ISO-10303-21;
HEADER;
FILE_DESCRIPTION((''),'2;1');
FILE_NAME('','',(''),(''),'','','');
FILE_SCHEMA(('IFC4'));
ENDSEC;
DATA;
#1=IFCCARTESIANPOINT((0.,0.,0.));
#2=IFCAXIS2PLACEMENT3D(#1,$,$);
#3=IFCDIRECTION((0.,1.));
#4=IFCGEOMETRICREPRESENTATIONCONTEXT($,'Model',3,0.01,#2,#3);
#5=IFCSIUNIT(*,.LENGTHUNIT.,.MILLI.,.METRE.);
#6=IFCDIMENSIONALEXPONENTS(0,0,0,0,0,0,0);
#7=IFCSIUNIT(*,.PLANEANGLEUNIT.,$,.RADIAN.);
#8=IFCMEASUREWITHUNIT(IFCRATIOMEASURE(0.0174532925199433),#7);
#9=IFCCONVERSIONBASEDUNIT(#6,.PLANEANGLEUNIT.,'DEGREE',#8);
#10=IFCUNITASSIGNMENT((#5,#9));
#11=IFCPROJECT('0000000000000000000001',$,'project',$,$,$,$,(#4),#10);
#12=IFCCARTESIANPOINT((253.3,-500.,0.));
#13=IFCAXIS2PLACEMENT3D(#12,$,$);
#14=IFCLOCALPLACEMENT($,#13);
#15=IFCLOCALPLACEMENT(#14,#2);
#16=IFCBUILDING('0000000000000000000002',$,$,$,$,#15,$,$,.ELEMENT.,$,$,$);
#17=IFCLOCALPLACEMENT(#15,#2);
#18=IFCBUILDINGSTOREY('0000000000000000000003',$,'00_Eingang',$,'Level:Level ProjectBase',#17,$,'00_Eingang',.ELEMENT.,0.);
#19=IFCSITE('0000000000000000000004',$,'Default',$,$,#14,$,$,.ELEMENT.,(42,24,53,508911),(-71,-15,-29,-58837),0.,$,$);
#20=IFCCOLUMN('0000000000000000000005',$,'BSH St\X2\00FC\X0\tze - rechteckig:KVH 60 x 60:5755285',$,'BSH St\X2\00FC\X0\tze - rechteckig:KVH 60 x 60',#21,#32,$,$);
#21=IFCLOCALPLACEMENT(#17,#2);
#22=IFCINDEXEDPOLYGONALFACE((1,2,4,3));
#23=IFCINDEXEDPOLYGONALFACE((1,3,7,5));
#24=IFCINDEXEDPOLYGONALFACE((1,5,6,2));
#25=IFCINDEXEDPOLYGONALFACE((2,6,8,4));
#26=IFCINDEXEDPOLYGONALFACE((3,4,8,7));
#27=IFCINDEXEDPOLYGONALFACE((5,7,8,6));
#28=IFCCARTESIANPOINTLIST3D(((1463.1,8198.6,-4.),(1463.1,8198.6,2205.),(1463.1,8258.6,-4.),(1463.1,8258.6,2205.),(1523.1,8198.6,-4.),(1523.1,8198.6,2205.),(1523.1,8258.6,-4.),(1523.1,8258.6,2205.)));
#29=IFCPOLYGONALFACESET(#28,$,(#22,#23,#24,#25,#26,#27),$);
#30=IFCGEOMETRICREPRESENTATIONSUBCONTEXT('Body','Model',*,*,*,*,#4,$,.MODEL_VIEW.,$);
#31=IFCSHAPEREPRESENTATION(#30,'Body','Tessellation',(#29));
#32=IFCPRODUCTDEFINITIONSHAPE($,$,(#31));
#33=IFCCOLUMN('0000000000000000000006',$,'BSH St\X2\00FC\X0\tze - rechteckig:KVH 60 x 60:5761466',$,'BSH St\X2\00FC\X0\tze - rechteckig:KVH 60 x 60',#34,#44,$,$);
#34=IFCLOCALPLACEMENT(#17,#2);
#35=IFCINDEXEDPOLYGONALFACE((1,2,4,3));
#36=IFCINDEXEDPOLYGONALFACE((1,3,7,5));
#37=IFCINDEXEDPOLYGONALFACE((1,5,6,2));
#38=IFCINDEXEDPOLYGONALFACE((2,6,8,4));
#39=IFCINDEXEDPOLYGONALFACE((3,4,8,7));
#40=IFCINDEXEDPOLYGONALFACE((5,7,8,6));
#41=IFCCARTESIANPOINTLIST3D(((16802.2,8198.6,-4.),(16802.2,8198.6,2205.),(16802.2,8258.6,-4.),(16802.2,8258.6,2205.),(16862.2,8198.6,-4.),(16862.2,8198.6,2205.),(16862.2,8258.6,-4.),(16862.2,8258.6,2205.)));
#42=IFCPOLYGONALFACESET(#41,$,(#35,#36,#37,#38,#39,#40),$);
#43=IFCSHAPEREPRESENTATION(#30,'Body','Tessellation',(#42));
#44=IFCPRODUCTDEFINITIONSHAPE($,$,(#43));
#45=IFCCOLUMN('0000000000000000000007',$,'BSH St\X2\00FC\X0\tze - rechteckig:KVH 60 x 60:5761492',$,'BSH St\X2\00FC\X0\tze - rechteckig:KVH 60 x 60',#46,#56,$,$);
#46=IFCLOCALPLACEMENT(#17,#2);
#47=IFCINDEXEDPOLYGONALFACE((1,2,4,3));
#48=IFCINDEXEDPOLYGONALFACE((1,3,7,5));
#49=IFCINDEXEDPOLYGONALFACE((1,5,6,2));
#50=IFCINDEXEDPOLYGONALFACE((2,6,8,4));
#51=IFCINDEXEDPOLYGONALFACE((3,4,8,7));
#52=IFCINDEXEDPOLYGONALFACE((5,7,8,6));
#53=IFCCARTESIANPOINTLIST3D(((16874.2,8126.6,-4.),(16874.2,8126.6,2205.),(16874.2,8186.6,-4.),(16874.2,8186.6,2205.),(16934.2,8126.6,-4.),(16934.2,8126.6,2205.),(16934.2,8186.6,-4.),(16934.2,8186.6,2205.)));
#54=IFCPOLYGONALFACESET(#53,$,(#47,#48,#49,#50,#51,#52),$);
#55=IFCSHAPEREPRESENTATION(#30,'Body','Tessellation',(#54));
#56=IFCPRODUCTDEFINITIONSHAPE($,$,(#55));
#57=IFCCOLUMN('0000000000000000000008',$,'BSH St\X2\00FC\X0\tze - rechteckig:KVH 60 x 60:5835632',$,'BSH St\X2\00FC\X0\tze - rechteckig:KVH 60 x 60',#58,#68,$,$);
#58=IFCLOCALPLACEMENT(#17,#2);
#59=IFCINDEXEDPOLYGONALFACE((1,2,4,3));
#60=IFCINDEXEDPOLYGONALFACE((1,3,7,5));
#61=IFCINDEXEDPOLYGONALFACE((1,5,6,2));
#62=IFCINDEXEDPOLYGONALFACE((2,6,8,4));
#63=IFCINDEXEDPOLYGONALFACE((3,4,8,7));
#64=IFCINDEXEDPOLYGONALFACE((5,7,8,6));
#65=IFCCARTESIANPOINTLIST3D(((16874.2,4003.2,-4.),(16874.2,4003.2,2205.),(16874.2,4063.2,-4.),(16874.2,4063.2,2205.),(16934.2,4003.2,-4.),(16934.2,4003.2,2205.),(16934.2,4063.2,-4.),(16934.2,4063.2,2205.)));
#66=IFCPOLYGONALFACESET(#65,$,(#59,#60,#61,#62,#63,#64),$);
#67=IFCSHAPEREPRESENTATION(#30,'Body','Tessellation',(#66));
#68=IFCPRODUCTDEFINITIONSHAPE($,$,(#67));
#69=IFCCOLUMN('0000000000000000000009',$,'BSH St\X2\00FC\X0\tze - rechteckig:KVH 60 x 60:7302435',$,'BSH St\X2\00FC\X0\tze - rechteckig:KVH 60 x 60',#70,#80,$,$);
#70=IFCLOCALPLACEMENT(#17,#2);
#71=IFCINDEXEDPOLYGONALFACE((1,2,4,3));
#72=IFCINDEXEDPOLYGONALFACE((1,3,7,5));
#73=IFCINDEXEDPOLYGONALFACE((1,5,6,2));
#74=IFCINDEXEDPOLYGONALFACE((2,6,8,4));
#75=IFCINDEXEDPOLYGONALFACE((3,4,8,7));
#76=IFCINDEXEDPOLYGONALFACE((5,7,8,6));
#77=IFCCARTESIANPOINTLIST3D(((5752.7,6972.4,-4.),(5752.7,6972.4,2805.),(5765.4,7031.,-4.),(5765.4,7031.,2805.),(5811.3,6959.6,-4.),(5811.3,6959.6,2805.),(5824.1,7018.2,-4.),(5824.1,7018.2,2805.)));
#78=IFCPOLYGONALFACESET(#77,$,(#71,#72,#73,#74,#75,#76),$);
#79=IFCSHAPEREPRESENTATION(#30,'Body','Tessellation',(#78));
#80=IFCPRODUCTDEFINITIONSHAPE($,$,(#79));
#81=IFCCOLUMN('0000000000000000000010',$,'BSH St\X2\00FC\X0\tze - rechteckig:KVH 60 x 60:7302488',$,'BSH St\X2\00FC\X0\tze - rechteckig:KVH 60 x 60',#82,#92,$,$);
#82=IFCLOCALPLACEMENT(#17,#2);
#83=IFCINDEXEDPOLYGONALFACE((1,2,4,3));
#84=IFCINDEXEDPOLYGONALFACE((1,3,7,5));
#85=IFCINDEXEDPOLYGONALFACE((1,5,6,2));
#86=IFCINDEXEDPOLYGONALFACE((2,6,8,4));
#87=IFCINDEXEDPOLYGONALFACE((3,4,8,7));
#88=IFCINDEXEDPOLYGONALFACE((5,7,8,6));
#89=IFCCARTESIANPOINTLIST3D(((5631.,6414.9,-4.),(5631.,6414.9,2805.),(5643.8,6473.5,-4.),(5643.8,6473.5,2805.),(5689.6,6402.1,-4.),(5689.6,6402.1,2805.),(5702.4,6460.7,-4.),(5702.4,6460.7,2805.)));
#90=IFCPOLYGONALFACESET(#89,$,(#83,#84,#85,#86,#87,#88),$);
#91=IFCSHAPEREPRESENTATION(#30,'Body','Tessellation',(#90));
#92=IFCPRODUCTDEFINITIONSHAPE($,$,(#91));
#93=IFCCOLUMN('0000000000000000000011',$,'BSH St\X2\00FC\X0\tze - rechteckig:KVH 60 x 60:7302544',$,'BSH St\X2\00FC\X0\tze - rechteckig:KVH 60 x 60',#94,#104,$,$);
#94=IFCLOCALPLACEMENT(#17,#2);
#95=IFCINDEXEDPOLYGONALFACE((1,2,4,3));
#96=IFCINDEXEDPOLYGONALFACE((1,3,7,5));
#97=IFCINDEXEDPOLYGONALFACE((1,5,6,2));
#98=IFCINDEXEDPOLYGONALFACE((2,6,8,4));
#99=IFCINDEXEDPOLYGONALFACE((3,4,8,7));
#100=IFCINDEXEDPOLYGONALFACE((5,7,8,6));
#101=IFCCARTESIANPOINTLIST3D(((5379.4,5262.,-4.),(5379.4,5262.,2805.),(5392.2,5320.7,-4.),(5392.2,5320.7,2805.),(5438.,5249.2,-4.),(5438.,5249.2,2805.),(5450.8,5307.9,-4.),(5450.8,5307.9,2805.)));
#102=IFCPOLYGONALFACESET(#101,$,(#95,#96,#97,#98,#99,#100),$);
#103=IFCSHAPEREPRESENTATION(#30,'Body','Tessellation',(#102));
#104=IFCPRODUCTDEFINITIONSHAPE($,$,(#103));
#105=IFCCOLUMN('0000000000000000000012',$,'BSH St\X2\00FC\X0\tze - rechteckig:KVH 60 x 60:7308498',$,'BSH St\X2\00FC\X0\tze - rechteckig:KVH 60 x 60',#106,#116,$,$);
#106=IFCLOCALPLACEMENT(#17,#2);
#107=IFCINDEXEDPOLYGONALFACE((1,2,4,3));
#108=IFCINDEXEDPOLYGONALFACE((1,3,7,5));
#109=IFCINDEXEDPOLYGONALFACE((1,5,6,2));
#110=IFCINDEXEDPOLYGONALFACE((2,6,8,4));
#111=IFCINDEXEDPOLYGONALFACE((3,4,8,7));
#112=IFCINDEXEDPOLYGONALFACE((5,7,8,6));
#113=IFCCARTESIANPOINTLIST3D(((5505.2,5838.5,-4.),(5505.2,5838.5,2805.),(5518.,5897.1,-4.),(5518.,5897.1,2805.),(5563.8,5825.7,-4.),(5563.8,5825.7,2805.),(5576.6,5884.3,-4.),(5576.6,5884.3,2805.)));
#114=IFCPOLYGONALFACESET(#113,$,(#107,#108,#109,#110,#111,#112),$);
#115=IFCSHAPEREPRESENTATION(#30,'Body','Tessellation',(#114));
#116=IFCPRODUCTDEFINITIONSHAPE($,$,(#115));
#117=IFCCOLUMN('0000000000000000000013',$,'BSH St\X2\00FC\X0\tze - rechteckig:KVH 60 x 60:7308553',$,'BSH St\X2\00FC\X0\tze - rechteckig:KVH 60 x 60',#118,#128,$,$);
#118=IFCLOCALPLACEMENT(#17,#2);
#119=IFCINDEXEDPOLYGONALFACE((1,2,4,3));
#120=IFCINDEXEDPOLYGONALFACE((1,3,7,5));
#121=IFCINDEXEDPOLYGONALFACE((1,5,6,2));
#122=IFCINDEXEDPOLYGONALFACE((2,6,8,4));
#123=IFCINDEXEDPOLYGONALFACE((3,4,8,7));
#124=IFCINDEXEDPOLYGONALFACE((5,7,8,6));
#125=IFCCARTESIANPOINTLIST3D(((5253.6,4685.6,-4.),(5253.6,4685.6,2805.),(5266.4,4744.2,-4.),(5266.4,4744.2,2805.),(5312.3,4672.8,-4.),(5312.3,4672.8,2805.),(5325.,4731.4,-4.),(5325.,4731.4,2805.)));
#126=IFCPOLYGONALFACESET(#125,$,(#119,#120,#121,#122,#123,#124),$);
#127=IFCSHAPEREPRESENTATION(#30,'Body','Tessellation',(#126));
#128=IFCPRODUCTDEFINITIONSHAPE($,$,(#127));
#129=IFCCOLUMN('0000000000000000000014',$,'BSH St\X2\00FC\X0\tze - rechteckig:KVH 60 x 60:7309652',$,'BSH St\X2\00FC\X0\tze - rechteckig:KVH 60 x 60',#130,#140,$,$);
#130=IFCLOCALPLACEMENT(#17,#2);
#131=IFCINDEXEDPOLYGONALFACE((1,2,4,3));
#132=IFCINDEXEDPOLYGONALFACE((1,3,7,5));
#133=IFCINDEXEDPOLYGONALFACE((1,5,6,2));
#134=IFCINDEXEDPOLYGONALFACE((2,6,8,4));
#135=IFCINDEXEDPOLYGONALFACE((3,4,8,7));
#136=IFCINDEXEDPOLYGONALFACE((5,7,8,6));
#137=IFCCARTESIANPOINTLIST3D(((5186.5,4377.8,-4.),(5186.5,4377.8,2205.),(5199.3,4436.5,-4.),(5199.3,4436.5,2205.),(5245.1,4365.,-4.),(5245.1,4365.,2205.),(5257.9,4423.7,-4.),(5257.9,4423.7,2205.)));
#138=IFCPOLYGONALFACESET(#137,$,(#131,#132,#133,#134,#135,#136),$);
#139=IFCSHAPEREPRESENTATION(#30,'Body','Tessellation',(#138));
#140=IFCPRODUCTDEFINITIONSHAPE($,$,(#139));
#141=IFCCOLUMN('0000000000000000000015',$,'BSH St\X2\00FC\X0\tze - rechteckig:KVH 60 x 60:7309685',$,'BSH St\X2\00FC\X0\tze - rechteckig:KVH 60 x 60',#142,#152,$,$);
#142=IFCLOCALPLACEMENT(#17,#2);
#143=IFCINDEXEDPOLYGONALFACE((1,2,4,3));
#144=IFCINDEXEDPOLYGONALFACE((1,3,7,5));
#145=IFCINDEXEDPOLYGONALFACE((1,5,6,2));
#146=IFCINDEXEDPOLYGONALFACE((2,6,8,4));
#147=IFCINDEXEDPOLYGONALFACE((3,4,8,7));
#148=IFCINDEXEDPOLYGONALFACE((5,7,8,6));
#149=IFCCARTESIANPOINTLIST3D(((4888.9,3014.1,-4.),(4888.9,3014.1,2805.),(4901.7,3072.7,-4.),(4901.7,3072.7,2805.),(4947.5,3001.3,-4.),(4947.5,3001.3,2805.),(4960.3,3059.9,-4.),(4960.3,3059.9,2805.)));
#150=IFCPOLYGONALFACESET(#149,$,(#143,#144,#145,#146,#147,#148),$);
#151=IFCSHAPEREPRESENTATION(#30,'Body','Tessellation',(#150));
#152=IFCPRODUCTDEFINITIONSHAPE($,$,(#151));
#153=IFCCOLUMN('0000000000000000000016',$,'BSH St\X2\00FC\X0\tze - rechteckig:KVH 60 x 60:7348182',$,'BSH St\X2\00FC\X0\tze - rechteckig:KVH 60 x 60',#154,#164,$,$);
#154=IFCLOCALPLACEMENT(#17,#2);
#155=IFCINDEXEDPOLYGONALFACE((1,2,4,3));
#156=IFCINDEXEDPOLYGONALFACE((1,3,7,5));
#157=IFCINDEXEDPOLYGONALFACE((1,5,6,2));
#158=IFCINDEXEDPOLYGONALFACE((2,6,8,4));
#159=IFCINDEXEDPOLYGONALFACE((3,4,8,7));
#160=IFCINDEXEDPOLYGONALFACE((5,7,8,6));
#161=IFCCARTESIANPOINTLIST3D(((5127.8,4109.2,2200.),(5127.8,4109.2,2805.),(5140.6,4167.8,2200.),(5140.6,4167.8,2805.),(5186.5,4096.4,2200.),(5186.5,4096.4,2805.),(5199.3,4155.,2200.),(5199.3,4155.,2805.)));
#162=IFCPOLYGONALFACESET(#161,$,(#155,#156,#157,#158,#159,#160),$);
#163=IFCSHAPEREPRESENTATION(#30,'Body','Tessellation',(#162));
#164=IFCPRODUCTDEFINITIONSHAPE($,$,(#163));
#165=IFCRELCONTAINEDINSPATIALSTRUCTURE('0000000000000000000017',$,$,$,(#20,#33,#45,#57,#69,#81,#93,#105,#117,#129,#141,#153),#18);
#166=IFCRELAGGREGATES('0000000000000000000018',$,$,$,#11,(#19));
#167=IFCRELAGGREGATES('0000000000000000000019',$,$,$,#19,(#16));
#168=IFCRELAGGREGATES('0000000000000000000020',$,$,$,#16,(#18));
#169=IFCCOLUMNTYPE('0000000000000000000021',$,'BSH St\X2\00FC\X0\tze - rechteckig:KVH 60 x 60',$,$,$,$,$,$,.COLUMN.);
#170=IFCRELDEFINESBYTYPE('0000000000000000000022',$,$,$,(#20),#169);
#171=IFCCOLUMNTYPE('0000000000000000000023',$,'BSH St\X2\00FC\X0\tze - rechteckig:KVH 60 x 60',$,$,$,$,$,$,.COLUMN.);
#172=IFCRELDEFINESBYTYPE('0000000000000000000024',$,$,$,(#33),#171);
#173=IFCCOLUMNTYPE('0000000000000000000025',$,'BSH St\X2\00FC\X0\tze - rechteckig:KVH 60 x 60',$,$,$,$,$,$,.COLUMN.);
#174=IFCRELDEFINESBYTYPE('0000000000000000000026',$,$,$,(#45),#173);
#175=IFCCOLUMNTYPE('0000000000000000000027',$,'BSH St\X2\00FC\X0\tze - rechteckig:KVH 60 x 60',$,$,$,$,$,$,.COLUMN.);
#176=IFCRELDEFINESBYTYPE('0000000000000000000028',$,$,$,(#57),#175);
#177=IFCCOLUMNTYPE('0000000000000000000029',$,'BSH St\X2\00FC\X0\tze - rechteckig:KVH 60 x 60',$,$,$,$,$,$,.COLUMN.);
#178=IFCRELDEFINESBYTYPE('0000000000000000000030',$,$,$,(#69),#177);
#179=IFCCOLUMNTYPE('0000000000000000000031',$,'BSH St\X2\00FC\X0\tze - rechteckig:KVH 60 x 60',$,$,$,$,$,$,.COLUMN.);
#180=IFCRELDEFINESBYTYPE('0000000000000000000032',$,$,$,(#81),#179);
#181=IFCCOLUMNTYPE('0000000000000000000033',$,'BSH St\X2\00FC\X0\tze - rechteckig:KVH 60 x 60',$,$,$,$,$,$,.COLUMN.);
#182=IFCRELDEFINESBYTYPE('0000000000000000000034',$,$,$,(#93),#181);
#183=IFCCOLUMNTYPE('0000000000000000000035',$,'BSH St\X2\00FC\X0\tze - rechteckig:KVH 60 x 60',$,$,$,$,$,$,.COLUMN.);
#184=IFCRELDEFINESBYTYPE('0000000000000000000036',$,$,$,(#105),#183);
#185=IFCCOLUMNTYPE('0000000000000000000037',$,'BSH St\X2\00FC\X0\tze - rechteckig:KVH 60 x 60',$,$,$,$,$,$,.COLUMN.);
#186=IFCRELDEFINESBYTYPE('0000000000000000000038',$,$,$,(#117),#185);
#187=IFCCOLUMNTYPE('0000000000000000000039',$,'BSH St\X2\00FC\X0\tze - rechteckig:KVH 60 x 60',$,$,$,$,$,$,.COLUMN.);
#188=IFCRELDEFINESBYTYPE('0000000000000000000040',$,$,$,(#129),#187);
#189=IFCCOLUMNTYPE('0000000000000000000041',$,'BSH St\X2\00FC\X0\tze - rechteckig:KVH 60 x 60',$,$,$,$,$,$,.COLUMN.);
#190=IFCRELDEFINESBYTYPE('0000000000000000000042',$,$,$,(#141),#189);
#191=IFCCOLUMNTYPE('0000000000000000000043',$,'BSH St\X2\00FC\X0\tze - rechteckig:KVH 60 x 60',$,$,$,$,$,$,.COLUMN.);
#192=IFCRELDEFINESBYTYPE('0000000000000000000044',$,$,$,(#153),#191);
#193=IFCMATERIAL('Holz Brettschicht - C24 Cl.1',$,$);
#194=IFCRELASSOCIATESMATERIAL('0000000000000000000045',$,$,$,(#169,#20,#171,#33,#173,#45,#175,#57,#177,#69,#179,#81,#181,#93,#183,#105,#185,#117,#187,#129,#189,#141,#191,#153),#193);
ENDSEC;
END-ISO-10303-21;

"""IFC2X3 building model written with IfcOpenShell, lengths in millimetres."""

from ifc_helpers import new_model, entity, si_unit, converted_unit, direction, frame, frame_2d, origin, origin_2d_with_axis, place, context, subcontext, project, spatial, rectangle, extrude, source, transform, mapped, material, type_object, type_shapes, element, save


model = new_model("IFC2X3")

# Units and contexts
model_context = context("Model", 3, precision=0.01, world=origin(), true_north=direction((0.0, 1.0)))
body_context = subcontext(model_context, "Body", "Model", "MODEL_VIEW")
ifc_project = project(units=[si_unit("LENGTHUNIT", "METRE", prefix="MILLI"), converted_unit("PLANEANGLEUNIT", "DEGREE", entity("IfcRatioMeasure", 0.0174532925199433), si_unit("PLANEANGLEUNIT", "RADIAN"), dimensions=[0, 0, 0, 0, 0, 0, 0])], contexts=[model_context])

# Site, building, storey
site_placement = place(None, frame((253.3, -500.0, 0.0)))
site = spatial("IfcSite", under=ifc_project, at=site_placement, Name="Default", CompositionType="ELEMENT", RefLatitude=(42, 24, 53, 508911), RefLongitude=(-71, -15, -29, -58837), RefElevation=0.0)
building_placement = place(site_placement, origin())
building = spatial("IfcBuilding", under=site, at=building_placement, CompositionType="ELEMENT")
storey_placement = place(building_placement, origin())
storey = spatial("IfcBuildingStorey", under=building, at=storey_placement, Name="00_Eingang", ObjectType="Level:Level ProjectBase", LongName="00_Eingang", CompositionType="ELEMENT", Elevation=0.0)

# Columns
ifc_material_1 = material(Name="Holz Brettschicht - C24 Cl.1")
column_type_1 = type_object("IfcColumnType", Name="BSH Stütze - rechteckig:KVH 60 x 60", PredefinedType="COLUMN", material=ifc_material_1)
shared_shape_1 = source(origin(), body_context, "Body", "SweptSolid", [
    extrude(rectangle(XDim=60.0, YDim=60.0, at=frame_2d((0.0, 0.0), x_axis=(1.0, 0.0))), frame((1493.1, 8228.6, -4.0), z_axis=(0.0, 0.0, 1.0), x_axis=(0.0, -1.0, 0.0)), (0.0, 0.0, 1.0), 2209.0),
])
type_shapes(column_type_1, [shared_shape_1])
column_1_placement = place(storey_placement, origin())
element("IfcColumn", 1, at=column_1_placement, inside=storey, type_object=column_type_1, material=ifc_material_1, Name="BSH Stütze - rechteckig:KVH 60 x 60:5755285", ObjectType="BSH Stütze - rechteckig:KVH 60 x 60", context=body_context, shape_type="MappedRepresentation", body=[
    mapped(shared_shape_1, transform((0.0, 0.0, 0.0), scale=1.0)),
])
column_type_2 = type_object("IfcColumnType", Name="BSH Stütze - rechteckig:KVH 60 x 60", PredefinedType="COLUMN", material=ifc_material_1)
shared_shape_2 = source(origin(), body_context, "Body", "SweptSolid", [
    extrude(rectangle(XDim=60.0, YDim=60.0, at=frame_2d((0.0, 0.0), x_axis=(1.0, 0.0))), frame((16832.2, 8228.6, -4.0), z_axis=(0.0, 0.0, 1.0), x_axis=(0.0, -1.0, 0.0)), (0.0, 0.0, 1.0), 2209.0),
])
type_shapes(column_type_2, [shared_shape_2])
column_2_placement = place(storey_placement, origin())
element("IfcColumn", 2, at=column_2_placement, inside=storey, type_object=column_type_2, material=ifc_material_1, Name="BSH Stütze - rechteckig:KVH 60 x 60:5761466", ObjectType="BSH Stütze - rechteckig:KVH 60 x 60", context=body_context, shape_type="MappedRepresentation", body=[
    mapped(shared_shape_2, transform((0.0, 0.0, 0.0), scale=1.0)),
])
column_type_3 = type_object("IfcColumnType", Name="BSH Stütze - rechteckig:KVH 60 x 60", PredefinedType="COLUMN", material=ifc_material_1)
shared_shape_3 = source(origin(), body_context, "Body", "SweptSolid", [
    extrude(rectangle(XDim=60.0, YDim=60.0, at=origin_2d_with_axis()), frame((16904.2, 8156.6, -4.0), z_axis=(0.0, 0.0, 1.0), x_axis=(0.0, -1.0, 0.0)), (0.0, 0.0, 1.0), 2209.0),
])
type_shapes(column_type_3, [shared_shape_3])
column_3_placement = place(storey_placement, origin())
element("IfcColumn", 3, at=column_3_placement, inside=storey, type_object=column_type_3, material=ifc_material_1, Name="BSH Stütze - rechteckig:KVH 60 x 60:5761492", ObjectType="BSH Stütze - rechteckig:KVH 60 x 60", context=body_context, shape_type="MappedRepresentation", body=[
    mapped(shared_shape_3, transform((0.0, 0.0, 0.0), scale=1.0)),
])
column_type_4 = type_object("IfcColumnType", Name="BSH Stütze - rechteckig:KVH 60 x 60", PredefinedType="COLUMN", material=ifc_material_1)
shared_shape_4 = source(origin(), body_context, "Body", "SweptSolid", [
    extrude(rectangle(XDim=60.0, YDim=60.0, at=frame_2d((0.0, 0.0), x_axis=(1.0, 0.0))), frame((16904.2, 4033.2, -4.0), z_axis=(0.0, 0.0, 1.0), x_axis=(0.0, -1.0, 0.0)), (0.0, 0.0, 1.0), 2209.0),
])
type_shapes(column_type_4, [shared_shape_4])
column_4_placement = place(storey_placement, origin())
element("IfcColumn", 4, at=column_4_placement, inside=storey, type_object=column_type_4, material=ifc_material_1, Name="BSH Stütze - rechteckig:KVH 60 x 60:5835632", ObjectType="BSH Stütze - rechteckig:KVH 60 x 60", context=body_context, shape_type="MappedRepresentation", body=[
    mapped(shared_shape_4, transform((0.0, 0.0, 0.0), scale=1.0)),
])
column_type_5 = type_object("IfcColumnType", Name="BSH Stütze - rechteckig:KVH 60 x 60", PredefinedType="COLUMN", material=ifc_material_1)
shared_shape_5 = source(origin(), body_context, "Body", "SweptSolid", [
    extrude(rectangle(XDim=60.0, YDim=60.0, at=frame_2d((0.0, 0.0), x_axis=(1.0, 0.0))), frame((5788.4, 6995.3, -4.0), z_axis=(0.0, 0.0, 1.0), x_axis=(0.213201, 0.977008, 0.0)), (0.0, 0.0, 1.0), 2809.0),
])
type_shapes(column_type_5, [shared_shape_5])
column_5_placement = place(storey_placement, origin())
element("IfcColumn", 5, at=column_5_placement, inside=storey, type_object=column_type_5, material=ifc_material_1, Name="BSH Stütze - rechteckig:KVH 60 x 60:7302435", ObjectType="BSH Stütze - rechteckig:KVH 60 x 60", context=body_context, shape_type="MappedRepresentation", body=[
    mapped(shared_shape_5, transform((0.0, 0.0, 0.0), scale=1.0)),
])
column_type_6 = type_object("IfcColumnType", Name="BSH Stütze - rechteckig:KVH 60 x 60", PredefinedType="COLUMN", material=ifc_material_1)
shared_shape_6 = source(origin(), body_context, "Body", "SweptSolid", [
    extrude(rectangle(XDim=60.0, YDim=60.0, at=frame_2d((0.0, 0.0), x_axis=(1.0, 0.0))), frame((5666.7, 6437.8, -4.0), z_axis=(0.0, 0.0, 1.0), x_axis=(0.213201, 0.977008, 0.0)), (0.0, 0.0, 1.0), 2809.0),
])
type_shapes(column_type_6, [shared_shape_6])
column_6_placement = place(storey_placement, origin())
element("IfcColumn", 6, at=column_6_placement, inside=storey, type_object=column_type_6, material=ifc_material_1, Name="BSH Stütze - rechteckig:KVH 60 x 60:7302488", ObjectType="BSH Stütze - rechteckig:KVH 60 x 60", context=body_context, shape_type="MappedRepresentation", body=[
    mapped(shared_shape_6, transform((0.0, 0.0, 0.0), scale=1.0)),
])
column_type_7 = type_object("IfcColumnType", Name="BSH Stütze - rechteckig:KVH 60 x 60", PredefinedType="COLUMN", material=ifc_material_1)
shared_shape_7 = source(origin(), body_context, "Body", "SweptSolid", [
    extrude(rectangle(XDim=60.0, YDim=60.0, at=frame_2d((0.0, 0.0), x_axis=(1.0, 0.0))), frame((5415.1, 5284.9, -4.0), z_axis=(0.0, 0.0, 1.0), x_axis=(0.213201, 0.977008, 0.0)), (0.0, 0.0, 1.0), 2809.0),
])
type_shapes(column_type_7, [shared_shape_7])
column_7_placement = place(storey_placement, origin())
element("IfcColumn", 7, at=column_7_placement, inside=storey, type_object=column_type_7, material=ifc_material_1, Name="BSH Stütze - rechteckig:KVH 60 x 60:7302544", ObjectType="BSH Stütze - rechteckig:KVH 60 x 60", context=body_context, shape_type="MappedRepresentation", body=[
    mapped(shared_shape_7, transform((0.0, 0.0, 0.0), scale=1.0)),
])
column_type_8 = type_object("IfcColumnType", Name="BSH Stütze - rechteckig:KVH 60 x 60", PredefinedType="COLUMN", material=ifc_material_1)
shared_shape_8 = source(origin(), body_context, "Body", "SweptSolid", [
    extrude(rectangle(XDim=60.0, YDim=60.0, at=frame_2d((0.0, 0.0), x_axis=(1.0, 0.0))), frame((5540.9, 5861.4, -4.0), z_axis=(0.0, 0.0, 1.0), x_axis=(0.213201, 0.977008, 0.0)), (0.0, 0.0, 1.0), 2809.0),
])
type_shapes(column_type_8, [shared_shape_8])
column_8_placement = place(storey_placement, origin())
element("IfcColumn", 8, at=column_8_placement, inside=storey, type_object=column_type_8, material=ifc_material_1, Name="BSH Stütze - rechteckig:KVH 60 x 60:7308498", ObjectType="BSH Stütze - rechteckig:KVH 60 x 60", context=body_context, shape_type="MappedRepresentation", body=[
    mapped(shared_shape_8, transform((0.0, 0.0, 0.0), scale=1.0)),
])
column_type_9 = type_object("IfcColumnType", Name="BSH Stütze - rechteckig:KVH 60 x 60", PredefinedType="COLUMN", material=ifc_material_1)
shared_shape_9 = source(origin(), body_context, "Body", "SweptSolid", [
    extrude(rectangle(XDim=60.0, YDim=60.0, at=frame_2d((0.0, 0.0), x_axis=(1.0, 0.0))), frame((5289.3, 4708.5, -4.0), z_axis=(0.0, 0.0, 1.0), x_axis=(0.213201, 0.977008, 0.0)), (0.0, 0.0, 1.0), 2809.0),
])
type_shapes(column_type_9, [shared_shape_9])
column_9_placement = place(storey_placement, origin())
element("IfcColumn", 9, at=column_9_placement, inside=storey, type_object=column_type_9, material=ifc_material_1, Name="BSH Stütze - rechteckig:KVH 60 x 60:7308553", ObjectType="BSH Stütze - rechteckig:KVH 60 x 60", context=body_context, shape_type="MappedRepresentation", body=[
    mapped(shared_shape_9, transform((0.0, 0.0, 0.0), scale=1.0)),
])
column_type_10 = type_object("IfcColumnType", Name="BSH Stütze - rechteckig:KVH 60 x 60", PredefinedType="COLUMN", material=ifc_material_1)
shared_shape_10 = source(origin(), body_context, "Body", "SweptSolid", [
    extrude(rectangle(XDim=60.0, YDim=60.0, at=frame_2d((0.0, 0.0), x_axis=(1.0, 0.0))), frame((5222.2, 4400.8, -4.0), z_axis=(0.0, 0.0, 1.0), x_axis=(0.213201, 0.977008, 0.0)), (0.0, 0.0, 1.0), 2209.0),
])
type_shapes(column_type_10, [shared_shape_10])
column_10_placement = place(storey_placement, origin())
element("IfcColumn", 10, at=column_10_placement, inside=storey, type_object=column_type_10, material=ifc_material_1, Name="BSH Stütze - rechteckig:KVH 60 x 60:7309652", ObjectType="BSH Stütze - rechteckig:KVH 60 x 60", context=body_context, shape_type="MappedRepresentation", body=[
    mapped(shared_shape_10, transform((0.0, 0.0, 0.0), scale=1.0)),
])
column_type_11 = type_object("IfcColumnType", Name="BSH Stütze - rechteckig:KVH 60 x 60", PredefinedType="COLUMN", material=ifc_material_1)
shared_shape_11 = source(origin(), body_context, "Body", "SweptSolid", [
    extrude(rectangle(XDim=60.0, YDim=60.0, at=frame_2d((0.0, 0.0), x_axis=(1.0, 0.0))), frame((4924.6, 3037.0, -4.0), z_axis=(0.0, 0.0, 1.0), x_axis=(0.213201, 0.977008, 0.0)), (0.0, 0.0, 1.0), 2809.0),
])
type_shapes(column_type_11, [shared_shape_11])
column_11_placement = place(storey_placement, origin())
element("IfcColumn", 11, at=column_11_placement, inside=storey, type_object=column_type_11, material=ifc_material_1, Name="BSH Stütze - rechteckig:KVH 60 x 60:7309685", ObjectType="BSH Stütze - rechteckig:KVH 60 x 60", context=body_context, shape_type="MappedRepresentation", body=[
    mapped(shared_shape_11, transform((0.0, 0.0, 0.0), scale=1.0)),
])
column_type_12 = type_object("IfcColumnType", Name="BSH Stütze - rechteckig:KVH 60 x 60", PredefinedType="COLUMN", material=ifc_material_1)
shared_shape_12 = source(origin(), body_context, "Body", "SweptSolid", [
    extrude(rectangle(XDim=60.0, YDim=60.0, at=frame_2d((0.0, 0.0), x_axis=(1.0, 0.0))), frame((5163.6, 4132.1, 2200.0), z_axis=(0.0, 0.0, 1.0), x_axis=(0.213201, 0.977008, 0.0)), (0.0, 0.0, 1.0), 605.0),
])
type_shapes(column_type_12, [shared_shape_12])
column_12_placement = place(storey_placement, origin())
element("IfcColumn", 12, at=column_12_placement, inside=storey, type_object=column_type_12, material=ifc_material_1, Name="BSH Stütze - rechteckig:KVH 60 x 60:7348182", ObjectType="BSH Stütze - rechteckig:KVH 60 x 60", context=body_context, shape_type="MappedRepresentation", body=[
    mapped(shared_shape_12, transform((0.0, 0.0, 0.0), scale=1.0)),
])

save(model, "model.ifc")
